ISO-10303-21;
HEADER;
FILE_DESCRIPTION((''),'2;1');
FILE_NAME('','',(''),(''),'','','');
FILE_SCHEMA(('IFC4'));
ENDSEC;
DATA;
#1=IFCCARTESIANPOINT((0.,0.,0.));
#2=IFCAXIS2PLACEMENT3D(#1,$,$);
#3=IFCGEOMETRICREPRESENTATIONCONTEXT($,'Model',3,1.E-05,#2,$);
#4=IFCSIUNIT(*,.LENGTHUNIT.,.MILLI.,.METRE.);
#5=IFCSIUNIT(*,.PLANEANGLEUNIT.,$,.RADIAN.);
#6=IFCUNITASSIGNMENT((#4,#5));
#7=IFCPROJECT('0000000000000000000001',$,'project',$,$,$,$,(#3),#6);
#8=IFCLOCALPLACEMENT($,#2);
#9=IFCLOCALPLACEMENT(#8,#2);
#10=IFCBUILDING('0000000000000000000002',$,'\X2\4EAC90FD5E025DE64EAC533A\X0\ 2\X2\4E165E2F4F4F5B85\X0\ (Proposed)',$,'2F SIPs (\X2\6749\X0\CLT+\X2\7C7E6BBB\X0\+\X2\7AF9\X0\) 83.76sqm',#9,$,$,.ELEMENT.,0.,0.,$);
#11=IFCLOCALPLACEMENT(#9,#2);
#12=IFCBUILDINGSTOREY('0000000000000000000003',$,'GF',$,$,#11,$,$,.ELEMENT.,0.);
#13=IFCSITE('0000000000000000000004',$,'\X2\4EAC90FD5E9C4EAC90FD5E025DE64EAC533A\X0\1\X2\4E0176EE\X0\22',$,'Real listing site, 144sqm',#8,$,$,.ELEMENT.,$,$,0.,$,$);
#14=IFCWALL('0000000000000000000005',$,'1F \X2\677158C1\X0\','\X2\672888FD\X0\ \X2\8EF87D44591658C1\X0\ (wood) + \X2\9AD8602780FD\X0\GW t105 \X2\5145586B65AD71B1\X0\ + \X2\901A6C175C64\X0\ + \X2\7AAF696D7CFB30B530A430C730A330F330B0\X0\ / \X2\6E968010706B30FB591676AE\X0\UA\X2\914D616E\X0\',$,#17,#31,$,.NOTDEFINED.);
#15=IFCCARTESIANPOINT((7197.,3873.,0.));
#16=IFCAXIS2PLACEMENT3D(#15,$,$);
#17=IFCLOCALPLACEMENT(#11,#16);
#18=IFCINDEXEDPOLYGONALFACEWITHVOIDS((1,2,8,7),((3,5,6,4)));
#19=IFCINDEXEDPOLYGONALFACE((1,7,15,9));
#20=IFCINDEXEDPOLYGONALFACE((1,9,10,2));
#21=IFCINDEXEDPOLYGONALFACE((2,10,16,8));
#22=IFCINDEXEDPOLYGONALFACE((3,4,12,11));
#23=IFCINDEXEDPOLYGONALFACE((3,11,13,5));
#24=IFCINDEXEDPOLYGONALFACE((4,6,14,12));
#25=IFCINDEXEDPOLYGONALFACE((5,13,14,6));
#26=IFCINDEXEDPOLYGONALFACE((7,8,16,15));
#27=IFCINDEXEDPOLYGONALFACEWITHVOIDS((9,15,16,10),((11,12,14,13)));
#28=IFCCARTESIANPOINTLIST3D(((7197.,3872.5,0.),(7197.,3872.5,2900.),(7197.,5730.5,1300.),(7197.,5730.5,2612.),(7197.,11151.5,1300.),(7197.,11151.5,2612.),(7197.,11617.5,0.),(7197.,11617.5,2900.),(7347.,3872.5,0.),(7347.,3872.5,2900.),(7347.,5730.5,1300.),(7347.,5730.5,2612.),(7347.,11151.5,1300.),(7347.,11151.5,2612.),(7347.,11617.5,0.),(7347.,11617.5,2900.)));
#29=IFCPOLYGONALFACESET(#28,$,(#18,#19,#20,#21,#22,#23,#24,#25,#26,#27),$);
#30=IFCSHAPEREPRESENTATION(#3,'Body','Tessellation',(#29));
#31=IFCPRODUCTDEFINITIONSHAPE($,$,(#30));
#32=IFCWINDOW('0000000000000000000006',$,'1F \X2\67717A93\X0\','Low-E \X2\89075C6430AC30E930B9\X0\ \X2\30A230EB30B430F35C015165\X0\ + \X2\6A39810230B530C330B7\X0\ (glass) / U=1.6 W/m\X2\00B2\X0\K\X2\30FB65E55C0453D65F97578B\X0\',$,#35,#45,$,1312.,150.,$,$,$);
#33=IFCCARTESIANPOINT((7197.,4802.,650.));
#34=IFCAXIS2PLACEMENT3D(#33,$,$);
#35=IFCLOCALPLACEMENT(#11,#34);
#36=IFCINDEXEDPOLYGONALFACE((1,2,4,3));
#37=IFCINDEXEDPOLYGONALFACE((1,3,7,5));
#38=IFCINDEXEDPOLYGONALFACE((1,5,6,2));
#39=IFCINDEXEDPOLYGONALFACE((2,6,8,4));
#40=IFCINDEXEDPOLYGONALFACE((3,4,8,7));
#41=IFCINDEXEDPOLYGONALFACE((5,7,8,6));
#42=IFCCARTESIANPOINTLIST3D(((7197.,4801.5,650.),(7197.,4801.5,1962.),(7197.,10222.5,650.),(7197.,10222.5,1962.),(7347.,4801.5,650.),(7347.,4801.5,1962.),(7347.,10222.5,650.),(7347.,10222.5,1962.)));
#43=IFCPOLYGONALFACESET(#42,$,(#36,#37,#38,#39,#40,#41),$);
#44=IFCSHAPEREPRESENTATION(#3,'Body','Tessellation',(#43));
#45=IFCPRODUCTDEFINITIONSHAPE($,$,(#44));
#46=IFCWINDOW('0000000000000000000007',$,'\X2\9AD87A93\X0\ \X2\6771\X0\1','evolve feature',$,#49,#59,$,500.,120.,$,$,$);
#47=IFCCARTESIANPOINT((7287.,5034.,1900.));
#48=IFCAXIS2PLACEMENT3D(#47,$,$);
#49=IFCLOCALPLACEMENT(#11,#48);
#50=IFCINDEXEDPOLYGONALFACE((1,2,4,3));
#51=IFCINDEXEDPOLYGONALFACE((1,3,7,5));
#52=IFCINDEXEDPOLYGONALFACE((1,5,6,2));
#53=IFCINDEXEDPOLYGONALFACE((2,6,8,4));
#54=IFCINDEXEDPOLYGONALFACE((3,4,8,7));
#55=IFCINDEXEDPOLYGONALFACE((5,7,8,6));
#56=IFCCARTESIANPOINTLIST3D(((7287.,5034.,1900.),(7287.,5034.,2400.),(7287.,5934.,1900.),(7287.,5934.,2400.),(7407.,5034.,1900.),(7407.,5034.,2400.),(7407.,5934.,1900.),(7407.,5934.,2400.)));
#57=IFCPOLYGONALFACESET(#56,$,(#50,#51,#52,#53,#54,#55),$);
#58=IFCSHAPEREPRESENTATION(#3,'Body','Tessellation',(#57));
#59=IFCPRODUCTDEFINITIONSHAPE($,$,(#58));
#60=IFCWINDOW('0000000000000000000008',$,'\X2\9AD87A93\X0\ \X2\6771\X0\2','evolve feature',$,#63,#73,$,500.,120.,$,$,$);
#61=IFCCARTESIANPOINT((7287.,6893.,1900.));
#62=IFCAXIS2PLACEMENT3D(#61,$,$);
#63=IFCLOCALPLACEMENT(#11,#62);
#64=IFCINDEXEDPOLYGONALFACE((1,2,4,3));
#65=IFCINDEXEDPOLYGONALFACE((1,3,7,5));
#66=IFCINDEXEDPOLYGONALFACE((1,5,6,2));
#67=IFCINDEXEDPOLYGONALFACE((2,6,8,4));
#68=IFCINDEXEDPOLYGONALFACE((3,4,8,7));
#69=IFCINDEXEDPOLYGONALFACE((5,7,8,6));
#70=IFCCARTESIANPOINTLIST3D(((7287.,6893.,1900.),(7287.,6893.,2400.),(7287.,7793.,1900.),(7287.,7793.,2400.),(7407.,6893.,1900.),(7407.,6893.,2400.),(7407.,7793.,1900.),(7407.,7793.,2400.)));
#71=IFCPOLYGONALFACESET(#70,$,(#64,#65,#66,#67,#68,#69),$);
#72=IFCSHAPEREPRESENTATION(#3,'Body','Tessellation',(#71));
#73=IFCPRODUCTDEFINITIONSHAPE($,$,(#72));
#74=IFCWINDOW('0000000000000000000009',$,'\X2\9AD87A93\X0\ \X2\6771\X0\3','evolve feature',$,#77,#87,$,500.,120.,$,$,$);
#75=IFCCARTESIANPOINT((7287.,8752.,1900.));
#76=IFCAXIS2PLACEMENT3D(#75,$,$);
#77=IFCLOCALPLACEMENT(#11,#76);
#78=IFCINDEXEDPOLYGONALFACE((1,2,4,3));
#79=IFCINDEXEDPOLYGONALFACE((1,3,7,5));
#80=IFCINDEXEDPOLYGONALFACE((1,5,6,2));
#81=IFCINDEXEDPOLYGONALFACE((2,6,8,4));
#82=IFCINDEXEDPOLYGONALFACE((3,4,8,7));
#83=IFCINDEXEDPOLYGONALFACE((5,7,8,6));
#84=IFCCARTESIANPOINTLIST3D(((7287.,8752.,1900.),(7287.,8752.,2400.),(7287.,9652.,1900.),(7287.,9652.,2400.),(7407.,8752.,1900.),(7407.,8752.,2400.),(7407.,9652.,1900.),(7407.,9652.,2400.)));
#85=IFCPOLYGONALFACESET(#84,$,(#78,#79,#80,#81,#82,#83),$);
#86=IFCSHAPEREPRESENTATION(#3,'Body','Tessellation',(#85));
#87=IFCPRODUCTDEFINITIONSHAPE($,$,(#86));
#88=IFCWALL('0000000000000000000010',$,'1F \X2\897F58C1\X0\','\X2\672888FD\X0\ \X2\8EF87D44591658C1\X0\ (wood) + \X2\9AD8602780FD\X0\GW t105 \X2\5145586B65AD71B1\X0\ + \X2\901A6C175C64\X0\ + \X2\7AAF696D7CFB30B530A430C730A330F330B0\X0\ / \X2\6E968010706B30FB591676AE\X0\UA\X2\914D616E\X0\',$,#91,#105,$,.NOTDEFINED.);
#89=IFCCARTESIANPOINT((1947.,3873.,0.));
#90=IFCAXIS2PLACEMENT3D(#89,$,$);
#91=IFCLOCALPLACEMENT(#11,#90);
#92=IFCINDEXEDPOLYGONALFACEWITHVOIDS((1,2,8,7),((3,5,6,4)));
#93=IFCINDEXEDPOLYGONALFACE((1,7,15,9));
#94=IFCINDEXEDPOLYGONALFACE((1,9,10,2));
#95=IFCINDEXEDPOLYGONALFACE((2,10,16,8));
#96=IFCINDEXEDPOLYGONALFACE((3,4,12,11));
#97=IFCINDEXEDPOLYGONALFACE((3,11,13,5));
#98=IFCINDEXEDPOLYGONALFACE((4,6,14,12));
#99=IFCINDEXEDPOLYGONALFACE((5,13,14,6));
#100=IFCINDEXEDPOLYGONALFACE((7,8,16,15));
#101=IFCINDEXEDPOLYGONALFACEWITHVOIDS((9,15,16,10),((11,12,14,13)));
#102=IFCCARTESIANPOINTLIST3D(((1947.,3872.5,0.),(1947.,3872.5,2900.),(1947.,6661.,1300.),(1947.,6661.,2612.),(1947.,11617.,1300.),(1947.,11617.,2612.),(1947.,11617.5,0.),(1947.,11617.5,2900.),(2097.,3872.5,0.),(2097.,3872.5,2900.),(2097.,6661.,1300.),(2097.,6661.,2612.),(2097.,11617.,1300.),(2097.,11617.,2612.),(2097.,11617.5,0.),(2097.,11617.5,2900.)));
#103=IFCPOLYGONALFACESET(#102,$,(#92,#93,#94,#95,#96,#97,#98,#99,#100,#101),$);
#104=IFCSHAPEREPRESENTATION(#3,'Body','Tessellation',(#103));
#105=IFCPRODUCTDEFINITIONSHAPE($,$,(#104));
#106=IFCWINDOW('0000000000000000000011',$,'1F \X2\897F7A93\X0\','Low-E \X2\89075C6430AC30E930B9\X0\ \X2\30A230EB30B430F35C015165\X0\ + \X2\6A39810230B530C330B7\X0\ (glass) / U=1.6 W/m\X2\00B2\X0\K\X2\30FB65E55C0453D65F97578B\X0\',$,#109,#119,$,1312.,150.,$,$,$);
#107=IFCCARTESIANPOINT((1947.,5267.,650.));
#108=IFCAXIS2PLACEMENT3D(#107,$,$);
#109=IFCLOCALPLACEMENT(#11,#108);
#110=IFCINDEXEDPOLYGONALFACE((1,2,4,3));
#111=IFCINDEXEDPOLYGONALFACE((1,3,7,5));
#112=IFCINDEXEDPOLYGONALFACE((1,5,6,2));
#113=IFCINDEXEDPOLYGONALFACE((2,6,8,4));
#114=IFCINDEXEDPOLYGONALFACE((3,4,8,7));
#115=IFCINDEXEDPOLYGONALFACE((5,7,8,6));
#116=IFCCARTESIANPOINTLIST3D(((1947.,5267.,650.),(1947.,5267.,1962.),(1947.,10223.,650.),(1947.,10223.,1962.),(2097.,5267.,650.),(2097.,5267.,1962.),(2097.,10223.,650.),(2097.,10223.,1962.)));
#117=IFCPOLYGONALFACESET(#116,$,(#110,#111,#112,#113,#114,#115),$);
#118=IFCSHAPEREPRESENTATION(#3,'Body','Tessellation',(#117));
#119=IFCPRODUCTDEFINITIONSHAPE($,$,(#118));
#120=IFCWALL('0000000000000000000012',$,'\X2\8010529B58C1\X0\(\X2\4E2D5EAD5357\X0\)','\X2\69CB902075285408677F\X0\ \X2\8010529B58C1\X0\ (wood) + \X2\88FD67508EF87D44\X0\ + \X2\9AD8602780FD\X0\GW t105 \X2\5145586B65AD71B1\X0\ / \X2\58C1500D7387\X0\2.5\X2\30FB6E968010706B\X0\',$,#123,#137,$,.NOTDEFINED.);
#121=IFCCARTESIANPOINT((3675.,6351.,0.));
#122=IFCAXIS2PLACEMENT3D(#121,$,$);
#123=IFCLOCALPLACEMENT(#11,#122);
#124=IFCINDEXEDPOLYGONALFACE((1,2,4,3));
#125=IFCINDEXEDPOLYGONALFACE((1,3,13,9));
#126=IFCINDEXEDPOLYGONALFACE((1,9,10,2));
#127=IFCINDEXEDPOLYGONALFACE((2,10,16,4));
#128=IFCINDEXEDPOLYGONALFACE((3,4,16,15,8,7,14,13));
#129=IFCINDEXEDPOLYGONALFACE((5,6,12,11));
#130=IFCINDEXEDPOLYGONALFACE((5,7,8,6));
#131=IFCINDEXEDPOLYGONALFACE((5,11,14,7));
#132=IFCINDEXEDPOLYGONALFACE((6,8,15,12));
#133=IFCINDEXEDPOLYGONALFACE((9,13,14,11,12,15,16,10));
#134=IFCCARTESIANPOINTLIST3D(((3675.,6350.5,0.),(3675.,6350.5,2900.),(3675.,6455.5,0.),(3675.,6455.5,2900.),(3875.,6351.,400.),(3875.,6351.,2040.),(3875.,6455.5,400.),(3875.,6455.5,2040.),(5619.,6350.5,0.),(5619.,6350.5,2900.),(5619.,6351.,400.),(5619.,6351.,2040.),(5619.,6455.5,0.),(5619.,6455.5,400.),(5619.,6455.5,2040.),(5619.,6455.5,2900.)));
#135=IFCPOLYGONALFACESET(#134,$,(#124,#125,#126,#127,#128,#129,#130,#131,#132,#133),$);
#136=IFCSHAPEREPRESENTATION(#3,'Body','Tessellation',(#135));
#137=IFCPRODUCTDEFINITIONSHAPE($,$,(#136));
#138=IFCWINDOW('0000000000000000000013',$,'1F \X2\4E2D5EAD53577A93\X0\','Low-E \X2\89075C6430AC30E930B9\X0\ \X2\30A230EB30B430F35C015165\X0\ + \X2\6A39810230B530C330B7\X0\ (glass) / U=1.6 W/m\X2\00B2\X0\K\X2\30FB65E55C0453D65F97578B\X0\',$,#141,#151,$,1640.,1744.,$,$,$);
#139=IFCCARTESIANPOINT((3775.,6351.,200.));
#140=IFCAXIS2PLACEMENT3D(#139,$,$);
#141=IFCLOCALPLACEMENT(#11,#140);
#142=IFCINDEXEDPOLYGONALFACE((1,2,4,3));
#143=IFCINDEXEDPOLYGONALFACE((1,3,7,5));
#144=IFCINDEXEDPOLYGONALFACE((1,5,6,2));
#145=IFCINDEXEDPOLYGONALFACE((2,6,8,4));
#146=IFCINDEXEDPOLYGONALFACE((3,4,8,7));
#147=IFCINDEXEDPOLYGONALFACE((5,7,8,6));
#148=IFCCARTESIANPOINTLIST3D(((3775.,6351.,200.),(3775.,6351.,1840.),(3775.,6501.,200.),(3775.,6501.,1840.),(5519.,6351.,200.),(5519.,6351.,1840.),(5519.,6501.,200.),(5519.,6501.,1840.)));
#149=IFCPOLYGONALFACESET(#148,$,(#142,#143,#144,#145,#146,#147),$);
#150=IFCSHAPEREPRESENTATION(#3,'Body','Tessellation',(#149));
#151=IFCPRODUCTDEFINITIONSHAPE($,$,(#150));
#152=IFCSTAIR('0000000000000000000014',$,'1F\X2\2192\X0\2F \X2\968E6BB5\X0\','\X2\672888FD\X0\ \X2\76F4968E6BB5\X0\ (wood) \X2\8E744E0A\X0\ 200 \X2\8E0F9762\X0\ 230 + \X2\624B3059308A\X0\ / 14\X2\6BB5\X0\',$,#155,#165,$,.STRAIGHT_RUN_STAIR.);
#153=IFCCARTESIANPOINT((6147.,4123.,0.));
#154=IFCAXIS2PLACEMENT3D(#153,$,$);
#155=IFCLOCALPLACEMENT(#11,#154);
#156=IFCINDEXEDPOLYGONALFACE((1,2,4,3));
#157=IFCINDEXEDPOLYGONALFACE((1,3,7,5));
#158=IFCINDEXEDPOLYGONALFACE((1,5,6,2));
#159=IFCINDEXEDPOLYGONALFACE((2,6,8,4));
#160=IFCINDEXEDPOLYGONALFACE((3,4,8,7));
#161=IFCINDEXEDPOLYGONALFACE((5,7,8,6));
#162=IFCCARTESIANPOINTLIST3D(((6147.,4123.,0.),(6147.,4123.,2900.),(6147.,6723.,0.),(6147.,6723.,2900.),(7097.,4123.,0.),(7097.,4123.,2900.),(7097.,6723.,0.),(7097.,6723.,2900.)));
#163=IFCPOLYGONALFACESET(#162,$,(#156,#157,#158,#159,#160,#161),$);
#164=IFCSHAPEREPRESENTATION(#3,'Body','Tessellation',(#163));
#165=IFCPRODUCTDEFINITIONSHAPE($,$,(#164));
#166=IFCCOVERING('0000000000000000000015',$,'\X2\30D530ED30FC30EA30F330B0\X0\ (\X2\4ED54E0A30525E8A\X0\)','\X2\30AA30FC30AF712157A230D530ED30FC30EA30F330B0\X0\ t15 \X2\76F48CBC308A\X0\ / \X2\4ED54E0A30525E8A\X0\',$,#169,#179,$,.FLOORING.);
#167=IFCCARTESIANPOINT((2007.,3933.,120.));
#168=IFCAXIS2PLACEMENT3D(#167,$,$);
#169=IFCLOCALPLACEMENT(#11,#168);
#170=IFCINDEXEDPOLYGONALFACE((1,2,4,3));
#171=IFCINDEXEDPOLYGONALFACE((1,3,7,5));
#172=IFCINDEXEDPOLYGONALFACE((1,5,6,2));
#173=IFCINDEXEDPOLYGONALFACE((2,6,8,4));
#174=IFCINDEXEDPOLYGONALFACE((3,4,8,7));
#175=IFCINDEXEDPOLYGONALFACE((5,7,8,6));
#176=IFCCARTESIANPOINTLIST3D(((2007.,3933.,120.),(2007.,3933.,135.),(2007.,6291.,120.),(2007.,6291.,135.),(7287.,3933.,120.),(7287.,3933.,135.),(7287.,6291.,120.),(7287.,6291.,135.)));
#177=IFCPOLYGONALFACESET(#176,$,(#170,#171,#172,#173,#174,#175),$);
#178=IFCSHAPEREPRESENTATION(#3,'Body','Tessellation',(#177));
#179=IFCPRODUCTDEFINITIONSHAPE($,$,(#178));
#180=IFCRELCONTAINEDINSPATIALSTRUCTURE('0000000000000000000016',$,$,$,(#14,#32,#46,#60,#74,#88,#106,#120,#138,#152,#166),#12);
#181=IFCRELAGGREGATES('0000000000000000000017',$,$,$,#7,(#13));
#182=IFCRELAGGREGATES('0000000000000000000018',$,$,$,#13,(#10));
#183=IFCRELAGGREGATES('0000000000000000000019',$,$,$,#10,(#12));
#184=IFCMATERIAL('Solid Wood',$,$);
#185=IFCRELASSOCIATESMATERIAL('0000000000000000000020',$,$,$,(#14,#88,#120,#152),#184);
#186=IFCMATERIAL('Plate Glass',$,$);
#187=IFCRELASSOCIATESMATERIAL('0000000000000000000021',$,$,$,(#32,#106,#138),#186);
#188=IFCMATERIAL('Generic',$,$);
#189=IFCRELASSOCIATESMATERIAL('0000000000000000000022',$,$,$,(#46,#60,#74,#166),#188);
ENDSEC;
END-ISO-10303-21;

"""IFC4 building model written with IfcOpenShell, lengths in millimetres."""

from ifc_helpers import new_model, si_unit, frame, frame_2d, origin, place, context, project, spatial, rectangle, extrude, material, element, fill, save


model = new_model("IFC4")

# Units and contexts
model_context = context("Model", 3, precision=1e-05, world=origin())
ifc_project = project(units=[si_unit("LENGTHUNIT", "METRE", prefix="MILLI"), si_unit("PLANEANGLEUNIT", "RADIAN")], contexts=[model_context])

# Site, building, storey
site_placement = place(None, origin())
site = spatial("IfcSite", under=ifc_project, at=site_placement, Name="京都府京都市左京区1丁目22", ObjectType="Real listing site, 144sqm", CompositionType="ELEMENT", RefElevation=0.0)
building_placement = place(site_placement, origin())
building = spatial("IfcBuilding", under=site, at=building_placement, Name="京都市左京区 2世帯住宅 (Proposed)", ObjectType="2F SIPs (杉CLT+籾殻+竹) 83.76sqm", CompositionType="ELEMENT", ElevationOfRefHeight=0.0, ElevationOfTerrain=0.0)
storey_placement = place(building_placement, origin())
storey = spatial("IfcBuildingStorey", under=building, at=storey_placement, Name="GF", CompositionType="ELEMENT", Elevation=0.0)

# Shared definitions
ifc_material_1 = material(Name="Solid Wood")
ifc_material_2 = material(Name="Generic")

# Shared definitions
ifc_material_3 = material(Name="Plate Glass")

# Wall, openings, windows
wall_1_placement = place(storey_placement, frame((7197.0, 3873.0, 0.0)))
wall_1 = element("IfcWall", 1, at=wall_1_placement, inside=storey, material=ifc_material_1, Name="1F 東壁", Description="木製 軸組外壁 (wood) + 高性能GW t105 充填断熱 + 通気層 + 窯業系サイディング / 準耐火・外皮UA配慮", PredefinedType="NOTDEFINED", context=model_context, shape_type="SweptSolid", body=[
    extrude(rectangle(XDim=150.0, YDim=7745.0, at=frame_2d((75.0, 3872.0))), frame((7197.0, 3873.0, 0.0)), (0.0, 0.0, 1.0), 2900.0),
])
opening_1_placement = place(storey_placement, frame((7197.0, 4802.0, 650.0)))
opening_1 = element("IfcOpeningElement", 2, at=opening_1_placement, cuts=wall_1, PredefinedType="NOTDEFINED", context=model_context, shape_type="SweptSolid", body=[
    extrude(rectangle(XDim=150.0, YDim=5421.0, at=frame_2d((75.0, 2710.0))), frame((7197.0, 4802.0, 650.0)), (0.0, 0.0, 1.0), 1312.0),
])
opening_2_placement = place(storey_placement, frame((7287.0, 5034.0, 1900.0)))
opening_2 = element("IfcOpeningElement", 3, at=opening_2_placement, cuts=wall_1, PredefinedType="NOTDEFINED", context=model_context, shape_type="SweptSolid", body=[
    extrude(rectangle(XDim=120.0, YDim=900.0, at=frame_2d((60.0, 450.0))), frame((7287.0, 5034.0, 1900.0)), (0.0, 0.0, 1.0), 500.0),
])
opening_3_placement = place(storey_placement, frame((7287.0, 6893.0, 1900.0)))
opening_3 = element("IfcOpeningElement", 4, at=opening_3_placement, cuts=wall_1, PredefinedType="NOTDEFINED", context=model_context, shape_type="SweptSolid", body=[
    extrude(rectangle(XDim=120.0, YDim=900.0, at=frame_2d((60.0, 450.0))), frame((7287.0, 6893.0, 1900.0)), (0.0, 0.0, 1.0), 500.0),
])
opening_4_placement = place(storey_placement, frame((7287.0, 8752.0, 1900.0)))
opening_4 = element("IfcOpeningElement", 5, at=opening_4_placement, cuts=wall_1, PredefinedType="NOTDEFINED", context=model_context, shape_type="SweptSolid", body=[
    extrude(rectangle(XDim=120.0, YDim=900.0, at=frame_2d((60.0, 450.0))), frame((7287.0, 8752.0, 1900.0)), (0.0, 0.0, 1.0), 500.0),
])
window_1_placement = place(storey_placement, frame((7197.0, 4802.0, 650.0)))
window_1 = element("IfcWindow", 6, at=window_1_placement, inside=storey, material=ifc_material_3, Name="1F 東窓", Description="Low-E 複層ガラス アルゴン封入 + 樹脂サッシ (glass) / U=1.6 W/m²K・日射取得型", OverallHeight=1312.0, OverallWidth=150.0, context=model_context, shape_type="SweptSolid", body=[
    extrude(rectangle(XDim=150.0, YDim=5421.0, at=frame_2d((75.0, 2710.0))), frame((7197.0, 4802.0, 650.0)), (0.0, 0.0, 1.0), 1312.0),
])
fill(opening_1, window_1)
window_2_placement = place(storey_placement, frame((7287.0, 5034.0, 1900.0)))
window_2 = element("IfcWindow", 7, at=window_2_placement, inside=storey, material=ifc_material_2, Name="高窓 東1", Description="evolve feature", OverallHeight=500.0, OverallWidth=120.0, context=model_context, shape_type="SweptSolid", body=[
    extrude(rectangle(XDim=120.0, YDim=900.0, at=frame_2d((60.0, 450.0))), frame((7287.0, 5034.0, 1900.0)), (0.0, 0.0, 1.0), 500.0),
])
fill(opening_2, window_2)
window_3_placement = place(storey_placement, frame((7287.0, 6893.0, 1900.0)))
window_3 = element("IfcWindow", 8, at=window_3_placement, inside=storey, material=ifc_material_2, Name="高窓 東2", Description="evolve feature", OverallHeight=500.0, OverallWidth=120.0, context=model_context, shape_type="SweptSolid", body=[
    extrude(rectangle(XDim=120.0, YDim=900.0, at=frame_2d((60.0, 450.0))), frame((7287.0, 6893.0, 1900.0)), (0.0, 0.0, 1.0), 500.0),
])
fill(opening_3, window_3)
window_4_placement = place(storey_placement, frame((7287.0, 8752.0, 1900.0)))
window_4 = element("IfcWindow", 9, at=window_4_placement, inside=storey, material=ifc_material_2, Name="高窓 東3", Description="evolve feature", OverallHeight=500.0, OverallWidth=120.0, context=model_context, shape_type="SweptSolid", body=[
    extrude(rectangle(XDim=120.0, YDim=900.0, at=frame_2d((60.0, 450.0))), frame((7287.0, 8752.0, 1900.0)), (0.0, 0.0, 1.0), 500.0),
])
fill(opening_4, window_4)

# Walls, openings, windows
wall_2_placement = place(storey_placement, frame((1947.0, 3873.0, 0.0)))
wall_2 = element("IfcWall", 10, at=wall_2_placement, inside=storey, material=ifc_material_1, Name="1F 西壁", Description="木製 軸組外壁 (wood) + 高性能GW t105 充填断熱 + 通気層 + 窯業系サイディング / 準耐火・外皮UA配慮", PredefinedType="NOTDEFINED", context=model_context, shape_type="SweptSolid", body=[
    extrude(rectangle(XDim=150.0, YDim=7745.0, at=frame_2d((75.0, 3872.0))), frame((1947.0, 3873.0, 0.0)), (0.0, 0.0, 1.0), 2900.0),
])
opening_5_placement = place(storey_placement, frame((1947.0, 5267.0, 650.0)))
opening_5 = element("IfcOpeningElement", 11, at=opening_5_placement, cuts=wall_2, PredefinedType="NOTDEFINED", context=model_context, shape_type="SweptSolid", body=[
    extrude(rectangle(XDim=150.0, YDim=4956.0, at=frame_2d((75.0, 2478.0))), frame((1947.0, 5267.0, 650.0)), (0.0, 0.0, 1.0), 1312.0),
])
window_5_placement = place(storey_placement, frame((1947.0, 5267.0, 650.0)))
window_5 = element("IfcWindow", 12, at=window_5_placement, inside=storey, material=ifc_material_3, Name="1F 西窓", Description="Low-E 複層ガラス アルゴン封入 + 樹脂サッシ (glass) / U=1.6 W/m²K・日射取得型", OverallHeight=1312.0, OverallWidth=150.0, context=model_context, shape_type="SweptSolid", body=[
    extrude(rectangle(XDim=150.0, YDim=4956.0, at=frame_2d((75.0, 2478.0))), frame((1947.0, 5267.0, 650.0)), (0.0, 0.0, 1.0), 1312.0),
])
fill(opening_5, window_5)
wall_3_placement = place(storey_placement, frame((3675.0, 6351.0, 0.0)))
wall_3 = element("IfcWall", 13, at=wall_3_placement, inside=storey, material=ifc_material_1, Name="耐力壁(中庭南)", Description="構造用合板 耐力壁 (wood) + 製材軸組 + 高性能GW t105 充填断熱 / 壁倍率2.5・準耐火", PredefinedType="NOTDEFINED", context=model_context, shape_type="SweptSolid", body=[
    extrude(rectangle(XDim=1944.0, YDim=105.0, at=frame_2d((972.0, 52.0))), frame((3675.0, 6351.0, 0.0)), (0.0, 0.0, 1.0), 2900.0),
])
opening_6_placement = place(storey_placement, frame((3775.0, 6351.0, 200.0)))
opening_6 = element("IfcOpeningElement", 14, at=opening_6_placement, cuts=wall_3, PredefinedType="NOTDEFINED", context=model_context, shape_type="SweptSolid", body=[
    extrude(rectangle(XDim=1744.0, YDim=150.0, at=frame_2d((872.0, 75.0))), frame((3775.0, 6351.0, 200.0)), (0.0, 0.0, 1.0), 1640.0),
])
window_6_placement = place(storey_placement, frame((3775.0, 6351.0, 200.0)))
window_6 = element("IfcWindow", 15, at=window_6_placement, inside=storey, material=ifc_material_3, Name="1F 中庭南窓", Description="Low-E 複層ガラス アルゴン封入 + 樹脂サッシ (glass) / U=1.6 W/m²K・日射取得型", OverallHeight=1640.0, OverallWidth=1744.0, context=model_context, shape_type="SweptSolid", body=[
    extrude(rectangle(XDim=1744.0, YDim=150.0, at=frame_2d((872.0, 75.0))), frame((3775.0, 6351.0, 200.0)), (0.0, 0.0, 1.0), 1640.0),
])
fill(opening_6, window_6)

# Stair
stair_placement = place(storey_placement, frame((6147.0, 4123.0, 0.0)))
element("IfcStair", 16, at=stair_placement, inside=storey, material=ifc_material_1, Name="1F→2F 階段", Description="木製 直階段 (wood) 蹴上 200 踏面 230 + 手すり / 14段", PredefinedType="STRAIGHT_RUN_STAIR", context=model_context, shape_type="SweptSolid", body=[
    extrude(rectangle(XDim=950.0, YDim=2600.0, at=frame_2d((475.0, 1300.0))), frame((6147.0, 4123.0, 0.0)), (0.0, 0.0, 1.0), 2900.0),
])

# Covering
covering_placement = place(storey_placement, frame((2007.0, 3933.0, 120.0)))
element("IfcCovering", 17, at=covering_placement, inside=storey, material=ifc_material_2, Name="フローリング (仕上げ床)", Description="オーク無垢フローリング t15 直貼り / 仕上げ床", PredefinedType="FLOORING", context=model_context, shape_type="SweptSolid", body=[
    extrude(rectangle(XDim=5280.0, YDim=2358.0, at=frame_2d((2640.0, 1179.0))), frame((2007.0, 3933.0, 120.0)), (0.0, 0.0, 1.0), 15.0),
])

save(model, "model.ifc")
